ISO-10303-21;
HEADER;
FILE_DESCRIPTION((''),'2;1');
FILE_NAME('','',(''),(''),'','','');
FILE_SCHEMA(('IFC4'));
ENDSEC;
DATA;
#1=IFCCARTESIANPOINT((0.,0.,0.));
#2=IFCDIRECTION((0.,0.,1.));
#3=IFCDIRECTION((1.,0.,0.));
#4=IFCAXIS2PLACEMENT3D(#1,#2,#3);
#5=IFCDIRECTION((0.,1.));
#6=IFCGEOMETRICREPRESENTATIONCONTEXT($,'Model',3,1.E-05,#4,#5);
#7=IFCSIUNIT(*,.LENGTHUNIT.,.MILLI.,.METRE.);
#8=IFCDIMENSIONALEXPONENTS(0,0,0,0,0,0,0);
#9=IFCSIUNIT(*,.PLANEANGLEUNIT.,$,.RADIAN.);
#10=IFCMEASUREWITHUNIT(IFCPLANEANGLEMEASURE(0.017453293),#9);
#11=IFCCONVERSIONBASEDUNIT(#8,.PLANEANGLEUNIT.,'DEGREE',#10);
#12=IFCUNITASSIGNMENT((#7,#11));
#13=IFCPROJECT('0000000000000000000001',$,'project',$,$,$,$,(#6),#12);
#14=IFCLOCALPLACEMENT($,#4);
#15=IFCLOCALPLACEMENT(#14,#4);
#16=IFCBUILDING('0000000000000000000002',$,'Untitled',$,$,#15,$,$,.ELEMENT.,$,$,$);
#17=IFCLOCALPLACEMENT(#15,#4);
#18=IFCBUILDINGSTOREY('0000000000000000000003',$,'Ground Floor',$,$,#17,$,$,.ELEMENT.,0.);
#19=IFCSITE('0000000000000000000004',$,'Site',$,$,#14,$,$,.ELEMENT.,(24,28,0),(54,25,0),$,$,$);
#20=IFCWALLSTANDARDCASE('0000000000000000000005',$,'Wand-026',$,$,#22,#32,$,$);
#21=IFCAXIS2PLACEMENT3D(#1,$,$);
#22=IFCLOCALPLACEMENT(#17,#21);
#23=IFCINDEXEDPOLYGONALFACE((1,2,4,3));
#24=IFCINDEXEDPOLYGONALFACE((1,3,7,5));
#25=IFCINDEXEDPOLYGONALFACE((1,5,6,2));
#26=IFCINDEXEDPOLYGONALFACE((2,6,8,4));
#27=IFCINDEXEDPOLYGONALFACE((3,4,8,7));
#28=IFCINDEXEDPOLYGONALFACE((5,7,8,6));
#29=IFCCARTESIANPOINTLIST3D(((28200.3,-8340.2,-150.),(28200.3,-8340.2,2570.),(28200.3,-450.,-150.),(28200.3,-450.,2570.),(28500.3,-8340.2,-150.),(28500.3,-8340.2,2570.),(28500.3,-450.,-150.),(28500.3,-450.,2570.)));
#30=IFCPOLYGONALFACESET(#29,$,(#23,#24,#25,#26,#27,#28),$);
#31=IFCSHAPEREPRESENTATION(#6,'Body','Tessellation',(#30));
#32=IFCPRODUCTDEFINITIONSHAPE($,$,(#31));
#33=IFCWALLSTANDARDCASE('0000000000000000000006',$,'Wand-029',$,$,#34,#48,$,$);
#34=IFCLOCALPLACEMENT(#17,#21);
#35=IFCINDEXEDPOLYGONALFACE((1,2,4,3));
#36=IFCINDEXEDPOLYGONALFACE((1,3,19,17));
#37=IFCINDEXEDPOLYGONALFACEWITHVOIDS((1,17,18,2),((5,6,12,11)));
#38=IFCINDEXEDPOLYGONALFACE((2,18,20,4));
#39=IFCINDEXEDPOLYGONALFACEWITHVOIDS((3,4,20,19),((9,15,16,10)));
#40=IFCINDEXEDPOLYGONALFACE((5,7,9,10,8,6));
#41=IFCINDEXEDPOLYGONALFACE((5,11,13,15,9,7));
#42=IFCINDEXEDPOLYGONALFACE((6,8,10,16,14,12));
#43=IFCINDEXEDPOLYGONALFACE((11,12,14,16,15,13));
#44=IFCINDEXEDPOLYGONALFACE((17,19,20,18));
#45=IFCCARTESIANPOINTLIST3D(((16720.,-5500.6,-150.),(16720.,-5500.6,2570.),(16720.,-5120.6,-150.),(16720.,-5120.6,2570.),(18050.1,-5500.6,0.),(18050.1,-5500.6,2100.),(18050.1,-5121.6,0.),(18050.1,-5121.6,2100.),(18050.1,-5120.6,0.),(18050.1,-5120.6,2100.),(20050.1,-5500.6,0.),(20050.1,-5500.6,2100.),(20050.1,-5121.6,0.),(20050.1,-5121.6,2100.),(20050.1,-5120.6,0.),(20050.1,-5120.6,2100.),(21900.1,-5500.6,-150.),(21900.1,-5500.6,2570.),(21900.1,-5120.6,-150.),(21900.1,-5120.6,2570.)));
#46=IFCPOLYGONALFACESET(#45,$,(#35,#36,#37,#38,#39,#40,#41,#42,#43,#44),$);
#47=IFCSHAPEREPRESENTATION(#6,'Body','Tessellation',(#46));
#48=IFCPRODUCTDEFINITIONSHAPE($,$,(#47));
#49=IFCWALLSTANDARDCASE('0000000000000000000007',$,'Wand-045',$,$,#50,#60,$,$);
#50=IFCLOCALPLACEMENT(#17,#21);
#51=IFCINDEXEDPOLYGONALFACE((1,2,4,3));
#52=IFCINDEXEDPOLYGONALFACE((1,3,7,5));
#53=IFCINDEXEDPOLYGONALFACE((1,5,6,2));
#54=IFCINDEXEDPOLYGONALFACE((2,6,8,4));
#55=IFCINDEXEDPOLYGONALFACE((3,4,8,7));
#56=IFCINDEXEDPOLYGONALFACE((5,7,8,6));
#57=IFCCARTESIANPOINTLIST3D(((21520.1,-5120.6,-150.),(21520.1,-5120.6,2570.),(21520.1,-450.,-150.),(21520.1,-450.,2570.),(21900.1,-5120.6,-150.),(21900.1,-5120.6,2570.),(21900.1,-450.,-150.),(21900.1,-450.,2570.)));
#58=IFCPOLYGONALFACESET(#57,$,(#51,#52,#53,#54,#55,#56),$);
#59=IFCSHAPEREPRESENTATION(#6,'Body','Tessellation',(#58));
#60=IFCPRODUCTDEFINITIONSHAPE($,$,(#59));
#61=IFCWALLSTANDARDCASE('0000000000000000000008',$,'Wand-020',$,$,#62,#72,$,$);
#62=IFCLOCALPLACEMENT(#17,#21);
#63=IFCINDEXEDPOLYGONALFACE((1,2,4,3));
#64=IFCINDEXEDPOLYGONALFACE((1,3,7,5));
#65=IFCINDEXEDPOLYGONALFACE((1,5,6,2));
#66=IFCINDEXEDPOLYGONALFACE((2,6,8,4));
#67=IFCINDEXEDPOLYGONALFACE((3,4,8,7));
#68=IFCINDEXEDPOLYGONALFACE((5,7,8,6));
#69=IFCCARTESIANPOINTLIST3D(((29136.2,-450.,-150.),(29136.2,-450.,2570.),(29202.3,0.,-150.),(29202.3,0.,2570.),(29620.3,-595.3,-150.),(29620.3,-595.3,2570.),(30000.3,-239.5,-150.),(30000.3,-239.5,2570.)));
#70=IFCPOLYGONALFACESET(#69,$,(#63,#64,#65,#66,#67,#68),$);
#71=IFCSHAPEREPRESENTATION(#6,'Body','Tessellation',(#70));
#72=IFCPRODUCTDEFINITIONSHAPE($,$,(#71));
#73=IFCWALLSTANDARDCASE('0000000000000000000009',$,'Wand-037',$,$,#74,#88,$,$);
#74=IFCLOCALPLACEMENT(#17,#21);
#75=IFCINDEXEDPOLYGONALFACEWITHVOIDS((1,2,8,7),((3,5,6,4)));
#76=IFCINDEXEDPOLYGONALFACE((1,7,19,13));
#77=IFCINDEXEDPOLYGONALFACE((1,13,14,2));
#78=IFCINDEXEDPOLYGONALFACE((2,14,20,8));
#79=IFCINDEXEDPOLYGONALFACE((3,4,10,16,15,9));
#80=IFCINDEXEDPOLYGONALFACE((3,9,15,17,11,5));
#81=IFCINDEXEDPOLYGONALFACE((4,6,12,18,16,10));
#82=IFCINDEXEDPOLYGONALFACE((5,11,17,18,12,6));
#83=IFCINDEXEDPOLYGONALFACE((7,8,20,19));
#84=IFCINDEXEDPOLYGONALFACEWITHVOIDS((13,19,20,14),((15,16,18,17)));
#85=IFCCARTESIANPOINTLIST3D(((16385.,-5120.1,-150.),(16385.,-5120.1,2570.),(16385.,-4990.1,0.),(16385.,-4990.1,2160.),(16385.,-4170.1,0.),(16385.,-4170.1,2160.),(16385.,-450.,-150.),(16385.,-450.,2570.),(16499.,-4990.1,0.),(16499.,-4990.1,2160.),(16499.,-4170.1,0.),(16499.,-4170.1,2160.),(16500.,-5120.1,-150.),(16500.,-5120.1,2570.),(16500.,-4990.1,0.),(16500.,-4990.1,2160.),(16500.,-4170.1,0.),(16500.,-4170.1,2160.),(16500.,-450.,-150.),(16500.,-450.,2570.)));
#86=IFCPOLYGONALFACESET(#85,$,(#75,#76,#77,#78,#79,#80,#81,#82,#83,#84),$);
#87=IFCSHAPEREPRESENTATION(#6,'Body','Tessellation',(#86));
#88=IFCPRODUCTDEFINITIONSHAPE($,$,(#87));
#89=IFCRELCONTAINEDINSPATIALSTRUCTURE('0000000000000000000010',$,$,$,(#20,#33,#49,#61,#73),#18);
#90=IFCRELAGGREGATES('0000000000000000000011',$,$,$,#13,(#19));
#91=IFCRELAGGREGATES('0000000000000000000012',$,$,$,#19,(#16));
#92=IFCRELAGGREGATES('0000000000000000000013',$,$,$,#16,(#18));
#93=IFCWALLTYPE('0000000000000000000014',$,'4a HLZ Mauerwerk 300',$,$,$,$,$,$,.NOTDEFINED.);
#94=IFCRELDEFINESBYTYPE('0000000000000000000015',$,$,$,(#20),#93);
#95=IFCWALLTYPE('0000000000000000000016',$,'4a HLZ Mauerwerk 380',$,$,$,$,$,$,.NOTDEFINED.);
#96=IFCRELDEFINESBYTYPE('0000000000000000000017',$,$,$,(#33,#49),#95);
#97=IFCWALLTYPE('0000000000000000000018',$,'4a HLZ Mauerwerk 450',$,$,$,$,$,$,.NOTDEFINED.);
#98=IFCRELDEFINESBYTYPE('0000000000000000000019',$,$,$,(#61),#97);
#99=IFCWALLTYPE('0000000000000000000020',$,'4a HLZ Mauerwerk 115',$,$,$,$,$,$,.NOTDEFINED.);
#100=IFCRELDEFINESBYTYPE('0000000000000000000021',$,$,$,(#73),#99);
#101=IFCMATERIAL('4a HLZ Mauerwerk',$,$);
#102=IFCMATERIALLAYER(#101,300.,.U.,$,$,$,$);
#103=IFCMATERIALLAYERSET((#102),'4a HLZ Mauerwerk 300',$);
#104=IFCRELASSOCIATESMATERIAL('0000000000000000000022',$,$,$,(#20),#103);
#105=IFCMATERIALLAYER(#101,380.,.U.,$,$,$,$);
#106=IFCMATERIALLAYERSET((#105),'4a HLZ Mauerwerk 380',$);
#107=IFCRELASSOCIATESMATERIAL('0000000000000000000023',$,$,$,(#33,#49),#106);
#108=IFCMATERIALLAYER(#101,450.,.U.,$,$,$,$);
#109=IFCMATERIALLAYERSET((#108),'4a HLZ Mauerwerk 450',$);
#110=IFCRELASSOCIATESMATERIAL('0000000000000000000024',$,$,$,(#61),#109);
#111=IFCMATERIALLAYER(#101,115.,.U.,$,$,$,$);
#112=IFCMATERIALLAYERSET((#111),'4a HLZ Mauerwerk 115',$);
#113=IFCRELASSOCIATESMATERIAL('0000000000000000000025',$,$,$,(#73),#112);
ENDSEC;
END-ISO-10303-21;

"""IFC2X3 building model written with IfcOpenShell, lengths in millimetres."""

from ifc_helpers import new_model, entity, si_unit, converted_unit, direction, frame, origin_with_axes, origin_2d_with_axis, place, context, project, spatial, polyline, rectangle, outline, extrude, material, layer, layer_set, layer_usage, type_object, element, save


model = new_model("IFC2X3")

# Units and contexts
model_context = context("Model", 3, precision=1e-05, world=origin_with_axes(), true_north=direction((0.0, 1.0)))
ifc_project = project(units=[si_unit("LENGTHUNIT", "METRE", prefix="MILLI"), converted_unit("PLANEANGLEUNIT", "DEGREE", entity("IfcPlaneAngleMeasure", 0.017453293), si_unit("PLANEANGLEUNIT", "RADIAN"), dimensions=[0, 0, 0, 0, 0, 0, 0])], contexts=[model_context])

# Site, building, storey
site_placement = place(None, origin_with_axes())
site = spatial("IfcSite", under=ifc_project, at=site_placement, Name="Site", CompositionType="ELEMENT", RefLatitude=(24, 28, 0), RefLongitude=(54, 25, 0))
building_placement = place(site_placement, origin_with_axes())
building = spatial("IfcBuilding", under=site, at=building_placement, Name="Untitled", CompositionType="ELEMENT")
storey_placement = place(building_placement, origin_with_axes())
storey = spatial("IfcBuildingStorey", under=building, at=storey_placement, Name="Ground Floor", CompositionType="ELEMENT", Elevation=0.0)

# Wall
ifc_material = material(Name="4a HLZ Mauerwerk")
ifc_layer_1 = layer(ifc_material, 300.0, ventilated="UNKNOWN")
ifc_layer_set_1 = layer_set([ifc_layer_1], Name="4a HLZ Mauerwerk 300")
ifc_layer_usage_1 = layer_usage(ifc_layer_set_1, "AXIS2", "POSITIVE", 0.0)
wall_type_1 = type_object("IfcWallType", Name="4a HLZ Mauerwerk 300", PredefinedType="NOTDEFINED")
wall_1_placement = place(storey_placement, frame((28200.3, -450.0, -150.0), z_axis=(0.0, 0.0, 1.0), x_axis=(0.0, -1.0, 0.0)))
element("IfcWallStandardCase", 1, at=wall_1_placement, inside=storey, type_object=wall_type_1, material=ifc_layer_usage_1, Name="Wand-026", context=model_context, shape_type="SweptSolid", body=[
    extrude(outline(polyline([(0.0, 0.0), (7890.2, 0.0), (7890.2, 300.0), (0.0, 300.0), (0.0, 0.0)])), origin_with_axes(), (0.0, 0.0, 1.0), 2720.0),
])

# Shared definitions
ifc_layer_2 = layer(ifc_material, 380.0, ventilated="UNKNOWN")
ifc_layer_set_2 = layer_set([ifc_layer_2], Name="4a HLZ Mauerwerk 380")
wall_type_2 = type_object("IfcWallType", Name="4a HLZ Mauerwerk 380", PredefinedType="NOTDEFINED")

# Wall, opening
ifc_layer_usage_2 = layer_usage(ifc_layer_set_2, "AXIS2", "NEGATIVE", 0.0)
wall_2_placement = place(storey_placement, frame((16720.0, -5120.6, -150.0), z_axis=(0.0, 0.0, 1.0), x_axis=(1.0, 0.0, 0.0)))
wall_2 = element("IfcWallStandardCase", 2, at=wall_2_placement, inside=storey, type_object=wall_type_2, material=ifc_layer_usage_2, Name="Wand-029", context=model_context, shape_type="SweptSolid", body=[
    extrude(outline(polyline([(0.0, -380.0), (5180.1, -380.0), (5180.1, 0.0), (0.0, 0.0), (0.0, -380.0)])), origin_with_axes(), (0.0, 0.0, 1.0), 2720.0),
])
opening_1_placement = place(wall_2_placement, frame((2330.1, 0.0, 150.0), z_axis=(0.0, 0.0, 1.0), x_axis=(1.0, 0.0, 0.0)))
element("IfcOpeningElement", 3, at=opening_1_placement, cuts=wall_2, context=model_context, shape_type="SweptSolid", body=[
    extrude(rectangle(XDim=2000.0, YDim=2100.0, at=origin_2d_with_axis()), frame((0.0, 761.0, 1050.0), z_axis=(0.0, -1.0, 0.0), x_axis=(1.0, 0.0, 0.0)), (0.0, 0.0, 1.0), 762.0),
    extrude(rectangle(XDim=2000.0, YDim=2100.0, at=origin_2d_with_axis()), frame((0.0, -761.0, 1050.0), z_axis=(0.0, 1.0, 0.0), x_axis=(1.0, 0.0, 0.0)), (0.0, 0.0, 1.0), 762.0),
])

# Walls
ifc_layer_usage_3 = layer_usage(ifc_layer_set_2, "AXIS2", "POSITIVE", 0.0)
wall_3_placement = place(storey_placement, frame((21520.1, -450.0, -150.0), z_axis=(0.0, 0.0, 1.0), x_axis=(0.0, -1.0, 0.0)))
element("IfcWallStandardCase", 4, at=wall_3_placement, inside=storey, type_object=wall_type_2, material=ifc_layer_usage_3, Name="Wand-045", context=model_context, shape_type="SweptSolid", body=[
    extrude(outline(polyline([(0.0, 0.0), (4670.6, 0.0), (4670.6, 380.0), (0.0, 380.0), (0.0, 0.0)])), origin_with_axes(), (0.0, 0.0, 1.0), 2720.0),
])
ifc_layer_3 = layer(ifc_material, 450.0, ventilated="UNKNOWN")
ifc_layer_set_3 = layer_set([ifc_layer_3], Name="4a HLZ Mauerwerk 450")
ifc_layer_usage_4 = layer_usage(ifc_layer_set_3, "AXIS2", "POSITIVE", 0.0)
wall_type_3 = type_object("IfcWallType", Name="4a HLZ Mauerwerk 450", PredefinedType="NOTDEFINED")
wall_4_placement = place(storey_placement, frame((29136.2, -450.0, -150.0), z_axis=(0.0, 0.0, 1.0), x_axis=(0.957788, -0.287475, 0.0)))
element("IfcWallStandardCase", 5, at=wall_4_placement, inside=storey, type_object=wall_type_3, material=ifc_layer_usage_4, Name="Wand-020", context=model_context, shape_type="SweptSolid", body=[
    extrude(outline(polyline([(0.0, 0.0), (505.4, 0.0), (767.1, 450.0), (-66.1, 450.0), (0.0, 0.0)])), origin_with_axes(), (0.0, 0.0, 1.0), 2720.0),
])

# Wall, opening
ifc_layer_4 = layer(ifc_material, 115.0, ventilated="UNKNOWN")
ifc_layer_set_4 = layer_set([ifc_layer_4], Name="4a HLZ Mauerwerk 115")
ifc_layer_usage_5 = layer_usage(ifc_layer_set_4, "AXIS2", "POSITIVE", 0.0)
wall_type_4 = type_object("IfcWallType", Name="4a HLZ Mauerwerk 115", PredefinedType="NOTDEFINED")
wall_5_placement = place(storey_placement, frame((16500.0, -5120.1, -150.0), z_axis=(0.0, 0.0, 1.0), x_axis=(0.0, 1.0, 0.0)))
wall_5 = element("IfcWallStandardCase", 6, at=wall_5_placement, inside=storey, type_object=wall_type_4, material=ifc_layer_usage_5, Name="Wand-037", context=model_context, shape_type="SweptSolid", body=[
    extrude(outline(polyline([(0.0, 0.0), (4670.1, 0.0), (4670.1, 115.0), (0.0, 115.0), (0.0, 0.0)])), origin_with_axes(), (0.0, 0.0, 1.0), 2720.0),
])
opening_2_placement = place(wall_5_placement, frame((540.0, 0.0, 150.0), z_axis=(0.0, 0.0, 1.0), x_axis=(1.0, 0.0, 0.0)))
element("IfcOpeningElement", 7, at=opening_2_placement, cuts=wall_5, context=model_context, shape_type="SweptSolid", body=[
    extrude(rectangle(XDim=820.0, YDim=2160.0, at=origin_2d_with_axis()), frame((0.0, -231.0, 1080.0), z_axis=(0.0, 1.0, 0.0), x_axis=(1.0, 0.0, 0.0)), (0.0, 0.0, 1.0), 232.0),
    extrude(rectangle(XDim=820.0, YDim=2160.0, at=origin_2d_with_axis()), frame((0.0, 231.0, 1080.0), z_axis=(0.0, -1.0, 0.0), x_axis=(1.0, 0.0, 0.0)), (0.0, 0.0, 1.0), 232.0),
])

save(model, "model.ifc")
